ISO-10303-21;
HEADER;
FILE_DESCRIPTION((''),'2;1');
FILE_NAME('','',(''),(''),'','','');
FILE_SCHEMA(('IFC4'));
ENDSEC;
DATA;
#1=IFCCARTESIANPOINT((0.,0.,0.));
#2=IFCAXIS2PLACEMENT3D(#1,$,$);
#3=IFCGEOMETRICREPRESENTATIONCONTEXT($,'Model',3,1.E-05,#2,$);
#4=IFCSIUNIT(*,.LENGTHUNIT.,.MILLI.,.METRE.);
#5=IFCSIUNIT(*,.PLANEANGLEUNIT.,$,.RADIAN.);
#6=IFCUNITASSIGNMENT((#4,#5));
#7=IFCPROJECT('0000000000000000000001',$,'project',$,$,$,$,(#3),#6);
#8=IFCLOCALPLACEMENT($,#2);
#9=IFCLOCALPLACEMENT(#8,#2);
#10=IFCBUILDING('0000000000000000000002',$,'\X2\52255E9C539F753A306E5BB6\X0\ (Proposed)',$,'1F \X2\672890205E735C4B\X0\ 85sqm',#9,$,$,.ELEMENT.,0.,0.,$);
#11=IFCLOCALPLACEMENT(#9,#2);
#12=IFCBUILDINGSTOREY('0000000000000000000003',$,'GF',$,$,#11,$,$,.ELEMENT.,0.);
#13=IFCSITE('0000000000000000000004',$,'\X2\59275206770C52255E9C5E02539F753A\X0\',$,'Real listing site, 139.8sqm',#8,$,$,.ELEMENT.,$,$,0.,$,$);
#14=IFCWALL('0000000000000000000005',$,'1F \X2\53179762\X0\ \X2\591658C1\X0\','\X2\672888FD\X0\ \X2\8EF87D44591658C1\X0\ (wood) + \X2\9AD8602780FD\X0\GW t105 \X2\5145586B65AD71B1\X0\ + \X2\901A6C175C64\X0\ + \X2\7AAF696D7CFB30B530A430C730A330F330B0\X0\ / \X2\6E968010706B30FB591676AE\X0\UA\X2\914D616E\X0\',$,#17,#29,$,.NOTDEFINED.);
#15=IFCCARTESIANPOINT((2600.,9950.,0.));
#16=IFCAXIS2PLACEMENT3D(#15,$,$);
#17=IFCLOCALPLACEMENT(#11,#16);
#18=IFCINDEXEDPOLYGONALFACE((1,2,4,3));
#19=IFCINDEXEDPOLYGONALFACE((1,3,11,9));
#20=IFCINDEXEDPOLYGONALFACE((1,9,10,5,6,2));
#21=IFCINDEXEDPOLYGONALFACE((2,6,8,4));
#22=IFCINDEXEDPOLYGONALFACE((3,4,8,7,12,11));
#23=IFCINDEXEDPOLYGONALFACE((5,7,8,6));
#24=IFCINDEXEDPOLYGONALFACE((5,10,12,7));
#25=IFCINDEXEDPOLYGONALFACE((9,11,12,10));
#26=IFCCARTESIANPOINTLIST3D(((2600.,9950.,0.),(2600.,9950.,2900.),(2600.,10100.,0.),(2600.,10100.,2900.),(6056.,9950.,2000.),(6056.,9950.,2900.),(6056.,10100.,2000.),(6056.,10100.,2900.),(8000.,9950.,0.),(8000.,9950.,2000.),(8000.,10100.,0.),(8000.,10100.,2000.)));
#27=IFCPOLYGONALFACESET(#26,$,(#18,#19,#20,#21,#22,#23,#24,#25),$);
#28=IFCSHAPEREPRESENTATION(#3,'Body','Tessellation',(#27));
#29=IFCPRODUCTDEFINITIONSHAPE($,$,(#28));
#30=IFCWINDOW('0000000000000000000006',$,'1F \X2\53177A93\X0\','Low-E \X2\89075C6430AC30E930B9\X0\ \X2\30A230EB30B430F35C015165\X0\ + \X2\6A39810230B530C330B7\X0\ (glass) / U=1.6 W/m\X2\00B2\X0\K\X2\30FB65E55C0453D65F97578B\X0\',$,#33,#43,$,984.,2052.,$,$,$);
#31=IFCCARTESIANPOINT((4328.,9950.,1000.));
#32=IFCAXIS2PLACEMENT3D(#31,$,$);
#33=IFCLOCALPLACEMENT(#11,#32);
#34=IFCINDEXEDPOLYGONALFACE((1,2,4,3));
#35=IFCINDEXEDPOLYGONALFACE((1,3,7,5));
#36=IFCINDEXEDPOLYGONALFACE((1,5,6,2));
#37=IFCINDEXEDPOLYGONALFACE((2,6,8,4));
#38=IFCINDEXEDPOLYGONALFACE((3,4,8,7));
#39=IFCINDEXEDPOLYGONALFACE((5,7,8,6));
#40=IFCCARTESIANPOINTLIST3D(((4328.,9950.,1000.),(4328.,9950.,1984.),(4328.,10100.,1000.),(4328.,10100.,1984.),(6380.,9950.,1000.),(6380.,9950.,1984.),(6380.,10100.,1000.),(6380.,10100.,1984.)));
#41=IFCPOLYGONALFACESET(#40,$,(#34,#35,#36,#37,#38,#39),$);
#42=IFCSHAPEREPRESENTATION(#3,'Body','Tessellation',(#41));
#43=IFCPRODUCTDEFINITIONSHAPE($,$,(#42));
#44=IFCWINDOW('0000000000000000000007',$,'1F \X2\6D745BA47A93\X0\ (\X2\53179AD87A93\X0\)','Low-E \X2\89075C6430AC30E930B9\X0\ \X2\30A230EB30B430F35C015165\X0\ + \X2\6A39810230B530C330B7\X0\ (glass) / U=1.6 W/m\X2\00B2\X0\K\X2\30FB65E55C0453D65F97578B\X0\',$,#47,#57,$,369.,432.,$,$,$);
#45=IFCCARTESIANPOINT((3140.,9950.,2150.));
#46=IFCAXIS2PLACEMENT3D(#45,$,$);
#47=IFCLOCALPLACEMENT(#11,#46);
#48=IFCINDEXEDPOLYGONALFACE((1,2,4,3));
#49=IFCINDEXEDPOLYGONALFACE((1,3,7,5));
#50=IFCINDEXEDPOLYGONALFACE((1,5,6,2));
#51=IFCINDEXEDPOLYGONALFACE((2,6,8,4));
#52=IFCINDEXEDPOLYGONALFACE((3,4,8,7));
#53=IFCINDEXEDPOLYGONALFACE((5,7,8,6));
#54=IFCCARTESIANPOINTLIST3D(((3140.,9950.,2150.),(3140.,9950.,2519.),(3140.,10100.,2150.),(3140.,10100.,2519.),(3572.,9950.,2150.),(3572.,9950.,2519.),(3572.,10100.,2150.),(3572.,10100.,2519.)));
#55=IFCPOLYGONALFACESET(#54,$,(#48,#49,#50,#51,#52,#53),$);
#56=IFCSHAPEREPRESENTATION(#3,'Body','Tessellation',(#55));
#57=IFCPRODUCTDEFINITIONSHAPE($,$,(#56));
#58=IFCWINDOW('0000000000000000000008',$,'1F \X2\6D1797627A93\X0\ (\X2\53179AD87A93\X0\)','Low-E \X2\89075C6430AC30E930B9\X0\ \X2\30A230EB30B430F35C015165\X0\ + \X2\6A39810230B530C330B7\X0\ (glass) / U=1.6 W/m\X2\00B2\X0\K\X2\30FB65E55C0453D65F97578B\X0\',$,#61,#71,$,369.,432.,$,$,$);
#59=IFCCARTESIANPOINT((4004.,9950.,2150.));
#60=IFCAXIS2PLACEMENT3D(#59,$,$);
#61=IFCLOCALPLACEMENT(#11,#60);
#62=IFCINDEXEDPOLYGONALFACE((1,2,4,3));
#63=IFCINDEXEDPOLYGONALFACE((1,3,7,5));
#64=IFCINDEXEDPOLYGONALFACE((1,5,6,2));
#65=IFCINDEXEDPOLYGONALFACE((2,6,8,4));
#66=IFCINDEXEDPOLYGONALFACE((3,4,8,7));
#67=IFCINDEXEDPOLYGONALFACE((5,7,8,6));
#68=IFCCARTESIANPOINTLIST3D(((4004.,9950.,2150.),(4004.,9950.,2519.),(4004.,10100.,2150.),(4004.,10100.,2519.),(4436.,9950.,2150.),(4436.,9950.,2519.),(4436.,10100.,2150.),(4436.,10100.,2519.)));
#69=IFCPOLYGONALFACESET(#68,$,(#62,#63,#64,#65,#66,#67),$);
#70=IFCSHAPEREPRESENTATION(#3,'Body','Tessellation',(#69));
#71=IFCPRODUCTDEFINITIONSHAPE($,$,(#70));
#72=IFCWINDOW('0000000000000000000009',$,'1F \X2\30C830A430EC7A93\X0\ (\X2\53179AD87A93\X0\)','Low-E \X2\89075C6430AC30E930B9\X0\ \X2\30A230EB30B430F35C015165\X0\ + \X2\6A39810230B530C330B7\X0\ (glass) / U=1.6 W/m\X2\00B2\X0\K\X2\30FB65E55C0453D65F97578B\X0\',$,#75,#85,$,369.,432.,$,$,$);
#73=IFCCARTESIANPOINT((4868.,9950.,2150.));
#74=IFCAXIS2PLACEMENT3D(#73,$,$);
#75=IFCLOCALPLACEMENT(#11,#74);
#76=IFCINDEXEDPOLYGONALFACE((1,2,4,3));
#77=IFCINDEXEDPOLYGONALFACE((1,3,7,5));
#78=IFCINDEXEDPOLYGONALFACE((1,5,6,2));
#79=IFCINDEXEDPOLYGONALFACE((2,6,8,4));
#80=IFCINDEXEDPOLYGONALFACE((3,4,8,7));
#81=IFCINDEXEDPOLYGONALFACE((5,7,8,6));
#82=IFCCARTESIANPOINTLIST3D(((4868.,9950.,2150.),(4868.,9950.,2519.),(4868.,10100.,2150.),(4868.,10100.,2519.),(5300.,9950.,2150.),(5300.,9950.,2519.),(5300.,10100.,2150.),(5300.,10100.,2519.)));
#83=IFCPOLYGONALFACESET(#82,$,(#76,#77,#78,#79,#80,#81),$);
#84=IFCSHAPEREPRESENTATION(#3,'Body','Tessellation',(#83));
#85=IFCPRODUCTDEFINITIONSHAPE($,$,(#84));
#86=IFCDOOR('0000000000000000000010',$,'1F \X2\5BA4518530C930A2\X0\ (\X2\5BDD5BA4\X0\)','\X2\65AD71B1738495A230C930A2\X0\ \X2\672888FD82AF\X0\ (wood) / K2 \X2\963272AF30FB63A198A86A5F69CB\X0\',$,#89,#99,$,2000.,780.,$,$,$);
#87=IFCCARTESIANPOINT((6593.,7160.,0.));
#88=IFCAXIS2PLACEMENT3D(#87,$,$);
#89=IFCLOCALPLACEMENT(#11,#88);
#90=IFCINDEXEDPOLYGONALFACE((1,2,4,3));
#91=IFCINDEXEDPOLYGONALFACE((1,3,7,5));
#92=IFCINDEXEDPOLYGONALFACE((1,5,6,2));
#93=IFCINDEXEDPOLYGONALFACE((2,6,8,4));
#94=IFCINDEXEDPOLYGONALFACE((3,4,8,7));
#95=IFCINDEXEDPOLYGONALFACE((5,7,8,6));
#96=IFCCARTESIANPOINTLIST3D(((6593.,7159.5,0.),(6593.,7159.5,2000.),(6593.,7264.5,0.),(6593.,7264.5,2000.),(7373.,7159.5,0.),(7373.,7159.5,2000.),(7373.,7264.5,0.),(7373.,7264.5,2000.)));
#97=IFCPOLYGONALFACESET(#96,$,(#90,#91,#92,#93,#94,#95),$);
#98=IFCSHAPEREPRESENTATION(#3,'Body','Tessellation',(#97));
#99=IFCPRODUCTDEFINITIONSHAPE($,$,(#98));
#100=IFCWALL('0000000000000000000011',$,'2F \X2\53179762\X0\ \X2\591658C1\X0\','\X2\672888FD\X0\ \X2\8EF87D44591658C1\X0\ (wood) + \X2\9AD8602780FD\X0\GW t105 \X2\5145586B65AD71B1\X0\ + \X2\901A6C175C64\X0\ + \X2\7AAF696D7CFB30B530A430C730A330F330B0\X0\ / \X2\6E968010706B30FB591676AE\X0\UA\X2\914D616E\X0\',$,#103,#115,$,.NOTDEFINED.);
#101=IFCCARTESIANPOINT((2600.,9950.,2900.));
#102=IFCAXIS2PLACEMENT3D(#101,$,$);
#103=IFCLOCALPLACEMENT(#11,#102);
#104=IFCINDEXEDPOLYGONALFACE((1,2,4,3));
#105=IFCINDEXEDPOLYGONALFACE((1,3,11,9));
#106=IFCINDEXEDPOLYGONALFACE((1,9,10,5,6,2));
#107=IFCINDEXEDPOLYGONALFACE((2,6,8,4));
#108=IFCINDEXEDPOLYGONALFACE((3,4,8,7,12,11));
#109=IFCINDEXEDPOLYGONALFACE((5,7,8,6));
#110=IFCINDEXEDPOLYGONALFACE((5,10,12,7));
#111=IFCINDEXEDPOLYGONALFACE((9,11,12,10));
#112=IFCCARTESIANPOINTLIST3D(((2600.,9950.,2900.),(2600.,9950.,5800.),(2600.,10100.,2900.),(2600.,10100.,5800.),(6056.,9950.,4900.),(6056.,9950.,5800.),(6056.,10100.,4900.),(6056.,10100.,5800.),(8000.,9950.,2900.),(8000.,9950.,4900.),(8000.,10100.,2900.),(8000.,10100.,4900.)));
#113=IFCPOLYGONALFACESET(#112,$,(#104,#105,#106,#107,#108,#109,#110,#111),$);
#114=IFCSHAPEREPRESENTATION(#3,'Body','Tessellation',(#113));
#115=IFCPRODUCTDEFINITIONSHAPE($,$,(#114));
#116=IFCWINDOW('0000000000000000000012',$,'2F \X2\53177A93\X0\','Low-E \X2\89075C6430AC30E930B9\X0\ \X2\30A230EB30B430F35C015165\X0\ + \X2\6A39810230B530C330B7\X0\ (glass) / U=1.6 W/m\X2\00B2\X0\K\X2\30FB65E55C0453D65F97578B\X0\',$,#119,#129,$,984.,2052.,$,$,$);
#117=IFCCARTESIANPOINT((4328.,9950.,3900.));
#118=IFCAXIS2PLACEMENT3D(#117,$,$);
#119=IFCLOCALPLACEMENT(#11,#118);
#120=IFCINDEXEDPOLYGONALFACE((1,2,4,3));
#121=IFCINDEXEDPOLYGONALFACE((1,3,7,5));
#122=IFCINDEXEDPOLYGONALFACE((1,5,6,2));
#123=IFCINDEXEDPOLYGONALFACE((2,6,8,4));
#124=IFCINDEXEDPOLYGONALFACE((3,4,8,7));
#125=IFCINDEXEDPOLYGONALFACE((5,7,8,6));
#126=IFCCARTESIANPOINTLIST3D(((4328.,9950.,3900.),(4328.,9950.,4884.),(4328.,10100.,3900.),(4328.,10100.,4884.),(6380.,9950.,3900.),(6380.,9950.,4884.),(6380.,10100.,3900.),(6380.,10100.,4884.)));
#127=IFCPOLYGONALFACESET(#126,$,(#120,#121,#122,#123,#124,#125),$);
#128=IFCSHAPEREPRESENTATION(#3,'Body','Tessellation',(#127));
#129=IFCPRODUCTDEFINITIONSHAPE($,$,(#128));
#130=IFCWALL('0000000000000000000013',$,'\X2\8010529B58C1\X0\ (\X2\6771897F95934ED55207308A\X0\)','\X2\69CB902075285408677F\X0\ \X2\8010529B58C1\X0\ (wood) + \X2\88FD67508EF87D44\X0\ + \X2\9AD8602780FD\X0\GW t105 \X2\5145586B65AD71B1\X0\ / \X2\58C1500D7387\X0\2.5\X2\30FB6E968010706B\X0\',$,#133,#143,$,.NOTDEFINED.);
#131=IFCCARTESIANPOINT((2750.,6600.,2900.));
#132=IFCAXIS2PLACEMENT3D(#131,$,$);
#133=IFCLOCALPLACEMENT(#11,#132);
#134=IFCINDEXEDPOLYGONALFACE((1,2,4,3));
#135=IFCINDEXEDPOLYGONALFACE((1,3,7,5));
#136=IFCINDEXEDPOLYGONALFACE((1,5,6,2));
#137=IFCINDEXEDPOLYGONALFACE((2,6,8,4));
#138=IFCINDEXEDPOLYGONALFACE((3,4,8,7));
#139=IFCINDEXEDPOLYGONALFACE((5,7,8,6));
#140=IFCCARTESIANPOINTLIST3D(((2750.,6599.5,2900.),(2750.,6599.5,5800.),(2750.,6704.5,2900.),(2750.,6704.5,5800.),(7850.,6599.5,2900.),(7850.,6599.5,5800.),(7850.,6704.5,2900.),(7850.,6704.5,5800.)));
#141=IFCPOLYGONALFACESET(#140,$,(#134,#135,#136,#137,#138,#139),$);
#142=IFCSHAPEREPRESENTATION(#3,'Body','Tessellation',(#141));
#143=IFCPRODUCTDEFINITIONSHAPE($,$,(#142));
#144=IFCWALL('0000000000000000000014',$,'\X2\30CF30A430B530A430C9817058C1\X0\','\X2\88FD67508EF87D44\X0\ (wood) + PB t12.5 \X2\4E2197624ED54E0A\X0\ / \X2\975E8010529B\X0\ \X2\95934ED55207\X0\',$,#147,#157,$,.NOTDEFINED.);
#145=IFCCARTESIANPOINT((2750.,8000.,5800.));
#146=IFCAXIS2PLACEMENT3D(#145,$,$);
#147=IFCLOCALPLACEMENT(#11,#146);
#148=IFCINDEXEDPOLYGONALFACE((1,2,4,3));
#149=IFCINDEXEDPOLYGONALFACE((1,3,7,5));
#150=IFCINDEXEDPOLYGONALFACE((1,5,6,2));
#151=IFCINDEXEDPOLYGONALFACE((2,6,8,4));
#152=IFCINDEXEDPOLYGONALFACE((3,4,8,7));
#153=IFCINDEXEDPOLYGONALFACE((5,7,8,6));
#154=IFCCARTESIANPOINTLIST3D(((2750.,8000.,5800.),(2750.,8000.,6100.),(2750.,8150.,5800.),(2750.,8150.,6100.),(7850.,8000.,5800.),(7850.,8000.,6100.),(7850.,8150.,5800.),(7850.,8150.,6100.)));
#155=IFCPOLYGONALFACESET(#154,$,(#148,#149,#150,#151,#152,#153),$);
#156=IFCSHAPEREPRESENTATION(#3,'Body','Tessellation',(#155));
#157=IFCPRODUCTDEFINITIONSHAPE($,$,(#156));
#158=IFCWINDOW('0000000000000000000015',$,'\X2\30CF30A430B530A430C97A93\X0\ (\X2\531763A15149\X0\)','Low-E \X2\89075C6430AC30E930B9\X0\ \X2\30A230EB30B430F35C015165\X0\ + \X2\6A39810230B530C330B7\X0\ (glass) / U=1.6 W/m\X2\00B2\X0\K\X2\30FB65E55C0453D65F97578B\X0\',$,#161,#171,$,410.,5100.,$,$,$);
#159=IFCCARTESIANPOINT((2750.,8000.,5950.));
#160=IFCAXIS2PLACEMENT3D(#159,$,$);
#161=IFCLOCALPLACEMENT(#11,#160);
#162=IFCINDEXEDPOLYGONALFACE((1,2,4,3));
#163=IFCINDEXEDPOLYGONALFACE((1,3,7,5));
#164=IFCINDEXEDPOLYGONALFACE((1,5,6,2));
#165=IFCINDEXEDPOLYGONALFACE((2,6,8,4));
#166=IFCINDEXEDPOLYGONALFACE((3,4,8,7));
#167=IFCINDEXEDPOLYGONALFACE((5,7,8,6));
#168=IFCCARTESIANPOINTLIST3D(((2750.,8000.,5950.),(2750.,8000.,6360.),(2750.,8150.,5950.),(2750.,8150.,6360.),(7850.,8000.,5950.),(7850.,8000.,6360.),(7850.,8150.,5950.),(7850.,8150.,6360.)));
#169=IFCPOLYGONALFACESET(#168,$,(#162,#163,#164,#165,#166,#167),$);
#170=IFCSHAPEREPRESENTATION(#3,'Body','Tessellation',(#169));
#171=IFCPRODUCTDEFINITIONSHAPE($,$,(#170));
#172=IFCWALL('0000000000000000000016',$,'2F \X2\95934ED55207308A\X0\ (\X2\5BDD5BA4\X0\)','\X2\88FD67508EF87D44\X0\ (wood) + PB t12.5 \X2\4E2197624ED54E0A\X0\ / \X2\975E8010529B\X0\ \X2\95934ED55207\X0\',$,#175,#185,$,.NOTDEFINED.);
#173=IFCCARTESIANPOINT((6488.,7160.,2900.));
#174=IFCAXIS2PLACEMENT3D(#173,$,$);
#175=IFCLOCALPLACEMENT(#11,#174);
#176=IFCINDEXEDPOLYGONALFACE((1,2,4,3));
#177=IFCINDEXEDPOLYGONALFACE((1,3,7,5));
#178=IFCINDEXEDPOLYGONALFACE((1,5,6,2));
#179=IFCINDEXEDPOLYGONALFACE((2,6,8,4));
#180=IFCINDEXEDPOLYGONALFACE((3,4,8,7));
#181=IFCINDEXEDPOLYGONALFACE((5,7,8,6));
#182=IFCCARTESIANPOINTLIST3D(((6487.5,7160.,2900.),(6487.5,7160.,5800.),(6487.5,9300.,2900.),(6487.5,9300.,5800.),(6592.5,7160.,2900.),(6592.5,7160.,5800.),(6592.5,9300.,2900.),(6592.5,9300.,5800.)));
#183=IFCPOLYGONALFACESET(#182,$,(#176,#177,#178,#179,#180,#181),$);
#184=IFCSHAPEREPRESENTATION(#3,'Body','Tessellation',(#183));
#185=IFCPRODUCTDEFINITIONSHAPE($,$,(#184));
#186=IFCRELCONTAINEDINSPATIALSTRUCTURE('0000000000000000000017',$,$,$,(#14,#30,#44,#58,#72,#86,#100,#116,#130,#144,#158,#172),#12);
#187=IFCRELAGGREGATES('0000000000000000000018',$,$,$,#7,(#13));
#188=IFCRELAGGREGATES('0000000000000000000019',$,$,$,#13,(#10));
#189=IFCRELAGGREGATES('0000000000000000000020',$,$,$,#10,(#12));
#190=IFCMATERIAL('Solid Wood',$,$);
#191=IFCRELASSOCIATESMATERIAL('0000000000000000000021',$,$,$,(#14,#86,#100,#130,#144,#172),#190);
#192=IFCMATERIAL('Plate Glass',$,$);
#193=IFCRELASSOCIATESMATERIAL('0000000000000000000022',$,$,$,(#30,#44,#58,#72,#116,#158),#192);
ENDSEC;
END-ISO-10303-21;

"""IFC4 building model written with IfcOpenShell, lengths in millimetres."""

from ifc_helpers import new_model, si_unit, frame, frame_2d, origin, place, context, project, spatial, rectangle, extrude, material, element, fill, save


model = new_model("IFC4")

# Units and contexts
model_context = context("Model", 3, precision=1e-05, world=origin())
ifc_project = project(units=[si_unit("LENGTHUNIT", "METRE", prefix="MILLI"), si_unit("PLANEANGLEUNIT", "RADIAN")], contexts=[model_context])

# Site, building, storey
site_placement = place(None, origin())
site = spatial("IfcSite", under=ifc_project, at=site_placement, Name="大分県別府市原町", ObjectType="Real listing site, 139.8sqm", CompositionType="ELEMENT", RefElevation=0.0)
building_placement = place(site_placement, origin())
building = spatial("IfcBuilding", under=site, at=building_placement, Name="別府原町の家 (Proposed)", ObjectType="1F 木造平屋 85sqm", CompositionType="ELEMENT", ElevationOfRefHeight=0.0, ElevationOfTerrain=0.0)
storey_placement = place(building_placement, origin())
storey = spatial("IfcBuildingStorey", under=building, at=storey_placement, Name="GF", CompositionType="ELEMENT", Elevation=0.0)

# Wall, openings, windows
ifc_material_1 = material(Name="Solid Wood")
wall_1_placement = place(storey_placement, frame((2600.0, 9950.0, 0.0)))
wall_1 = element("IfcWall", 1, at=wall_1_placement, inside=storey, material=ifc_material_1, Name="1F 北面 外壁", Description="木製 軸組外壁 (wood) + 高性能GW t105 充填断熱 + 通気層 + 窯業系サイディング / 準耐火・外皮UA配慮", PredefinedType="NOTDEFINED", context=model_context, shape_type="SweptSolid", body=[
    extrude(rectangle(XDim=5400.0, YDim=150.0, at=frame_2d((2700.0, 75.0))), frame((2600.0, 9950.0, 0.0)), (0.0, 0.0, 1.0), 2900.0),
])
opening_1_placement = place(storey_placement, frame((4328.0, 9950.0, 1000.0)))
opening_1 = element("IfcOpeningElement", 2, at=opening_1_placement, cuts=wall_1, PredefinedType="NOTDEFINED", context=model_context, shape_type="SweptSolid", body=[
    extrude(rectangle(XDim=2052.0, YDim=150.0, at=frame_2d((1026.0, 75.0))), frame((4328.0, 9950.0, 1000.0)), (0.0, 0.0, 1.0), 984.0),
])
opening_2_placement = place(storey_placement, frame((3140.0, 9950.0, 2150.0)))
opening_2 = element("IfcOpeningElement", 3, at=opening_2_placement, cuts=wall_1, PredefinedType="NOTDEFINED", context=model_context, shape_type="SweptSolid", body=[
    extrude(rectangle(XDim=432.0, YDim=150.0, at=frame_2d((216.0, 75.0))), frame((3140.0, 9950.0, 2150.0)), (0.0, 0.0, 1.0), 369.0),
])
opening_3_placement = place(storey_placement, frame((4004.0, 9950.0, 2150.0)))
opening_3 = element("IfcOpeningElement", 4, at=opening_3_placement, cuts=wall_1, PredefinedType="NOTDEFINED", context=model_context, shape_type="SweptSolid", body=[
    extrude(rectangle(XDim=432.0, YDim=150.0, at=frame_2d((216.0, 75.0))), frame((4004.0, 9950.0, 2150.0)), (0.0, 0.0, 1.0), 369.0),
])
opening_4_placement = place(storey_placement, frame((4868.0, 9950.0, 2150.0)))
opening_4 = element("IfcOpeningElement", 5, at=opening_4_placement, cuts=wall_1, PredefinedType="NOTDEFINED", context=model_context, shape_type="SweptSolid", body=[
    extrude(rectangle(XDim=432.0, YDim=150.0, at=frame_2d((216.0, 75.0))), frame((4868.0, 9950.0, 2150.0)), (0.0, 0.0, 1.0), 369.0),
])
ifc_material_2 = material(Name="Plate Glass")
window_1_placement = place(storey_placement, frame((4328.0, 9950.0, 1000.0)))
window_1 = element("IfcWindow", 6, at=window_1_placement, inside=storey, material=ifc_material_2, Name="1F 北窓", Description="Low-E 複層ガラス アルゴン封入 + 樹脂サッシ (glass) / U=1.6 W/m²K・日射取得型", OverallHeight=984.0, OverallWidth=2052.0, context=model_context, shape_type="SweptSolid", body=[
    extrude(rectangle(XDim=2052.0, YDim=150.0, at=frame_2d((1026.0, 75.0))), frame((4328.0, 9950.0, 1000.0)), (0.0, 0.0, 1.0), 984.0),
])
fill(opening_1, window_1)
window_2_placement = place(storey_placement, frame((3140.0, 9950.0, 2150.0)))
window_2 = element("IfcWindow", 7, at=window_2_placement, inside=storey, material=ifc_material_2, Name="1F 浴室窓 (北高窓)", Description="Low-E 複層ガラス アルゴン封入 + 樹脂サッシ (glass) / U=1.6 W/m²K・日射取得型", OverallHeight=369.0, OverallWidth=432.0, context=model_context, shape_type="SweptSolid", body=[
    extrude(rectangle(XDim=432.0, YDim=150.0, at=frame_2d((216.0, 75.0))), frame((3140.0, 9950.0, 2150.0)), (0.0, 0.0, 1.0), 369.0),
])
fill(opening_2, window_2)
window_3_placement = place(storey_placement, frame((4004.0, 9950.0, 2150.0)))
window_3 = element("IfcWindow", 8, at=window_3_placement, inside=storey, material=ifc_material_2, Name="1F 洗面窓 (北高窓)", Description="Low-E 複層ガラス アルゴン封入 + 樹脂サッシ (glass) / U=1.6 W/m²K・日射取得型", OverallHeight=369.0, OverallWidth=432.0, context=model_context, shape_type="SweptSolid", body=[
    extrude(rectangle(XDim=432.0, YDim=150.0, at=frame_2d((216.0, 75.0))), frame((4004.0, 9950.0, 2150.0)), (0.0, 0.0, 1.0), 369.0),
])
fill(opening_3, window_3)
window_4_placement = place(storey_placement, frame((4868.0, 9950.0, 2150.0)))
window_4 = element("IfcWindow", 9, at=window_4_placement, inside=storey, material=ifc_material_2, Name="1F トイレ窓 (北高窓)", Description="Low-E 複層ガラス アルゴン封入 + 樹脂サッシ (glass) / U=1.6 W/m²K・日射取得型", OverallHeight=369.0, OverallWidth=432.0, context=model_context, shape_type="SweptSolid", body=[
    extrude(rectangle(XDim=432.0, YDim=150.0, at=frame_2d((216.0, 75.0))), frame((4868.0, 9950.0, 2150.0)), (0.0, 0.0, 1.0), 369.0),
])
fill(opening_4, window_4)

# Door
door_1_placement = place(storey_placement, frame((6593.0, 7160.0, 0.0)))
element("IfcDoor", 10, at=door_1_placement, inside=storey, material=ifc_material_1, Name="1F 室内ドア (寝室)", Description="断熱玄関ドア 木製芯 (wood) / K2 防犯・採風機構", OverallHeight=2000.0, OverallWidth=780.0, context=model_context, shape_type="SweptSolid", body=[
    extrude(rectangle(XDim=780.0, YDim=105.0, at=frame_2d((390.0, 52.0))), frame((6593.0, 7160.0, 0.0)), (0.0, 0.0, 1.0), 2000.0),
])

# Wall, opening, window
wall_2_placement = place(storey_placement, frame((2600.0, 9950.0, 2900.0)))
wall_2 = element("IfcWall", 11, at=wall_2_placement, inside=storey, material=ifc_material_1, Name="2F 北面 外壁", Description="木製 軸組外壁 (wood) + 高性能GW t105 充填断熱 + 通気層 + 窯業系サイディング / 準耐火・外皮UA配慮", PredefinedType="NOTDEFINED", context=model_context, shape_type="SweptSolid", body=[
    extrude(rectangle(XDim=5400.0, YDim=150.0, at=frame_2d((2700.0, 75.0))), frame((2600.0, 9950.0, 2900.0)), (0.0, 0.0, 1.0), 2900.0),
])
opening_5_placement = place(storey_placement, frame((4328.0, 9950.0, 3900.0)))
opening_5 = element("IfcOpeningElement", 12, at=opening_5_placement, cuts=wall_2, PredefinedType="NOTDEFINED", context=model_context, shape_type="SweptSolid", body=[
    extrude(rectangle(XDim=2052.0, YDim=150.0, at=frame_2d((1026.0, 75.0))), frame((4328.0, 9950.0, 3900.0)), (0.0, 0.0, 1.0), 984.0),
])
window_5_placement = place(storey_placement, frame((4328.0, 9950.0, 3900.0)))
window_5 = element("IfcWindow", 13, at=window_5_placement, inside=storey, material=ifc_material_2, Name="2F 北窓", Description="Low-E 複層ガラス アルゴン封入 + 樹脂サッシ (glass) / U=1.6 W/m²K・日射取得型", OverallHeight=984.0, OverallWidth=2052.0, context=model_context, shape_type="SweptSolid", body=[
    extrude(rectangle(XDim=2052.0, YDim=150.0, at=frame_2d((1026.0, 75.0))), frame((4328.0, 9950.0, 3900.0)), (0.0, 0.0, 1.0), 984.0),
])
fill(opening_5, window_5)

# Wall
wall_3_placement = place(storey_placement, frame((2750.0, 6600.0, 2900.0)))
element("IfcWall", 14, at=wall_3_placement, inside=storey, material=ifc_material_1, Name="耐力壁 (東西間仕切り)", Description="構造用合板 耐力壁 (wood) + 製材軸組 + 高性能GW t105 充填断熱 / 壁倍率2.5・準耐火", PredefinedType="NOTDEFINED", context=model_context, shape_type="SweptSolid", body=[
    extrude(rectangle(XDim=5100.0, YDim=105.0, at=frame_2d((2550.0, 52.0))), frame((2750.0, 6600.0, 2900.0)), (0.0, 0.0, 1.0), 2900.0),
])

# Wall, opening, window
wall_4_placement = place(storey_placement, frame((2750.0, 8000.0, 5800.0)))
wall_4 = element("IfcWall", 15, at=wall_4_placement, inside=storey, material=ifc_material_1, Name="ハイサイド腰壁", Description="製材軸組 (wood) + PB t12.5 両面仕上 / 非耐力 間仕切", PredefinedType="NOTDEFINED", context=model_context, shape_type="SweptSolid", body=[
    extrude(rectangle(XDim=5100.0, YDim=150.0, at=frame_2d((2550.0, 75.0))), frame((2750.0, 8000.0, 5800.0)), (0.0, 0.0, 1.0), 700.0),
])
opening_6_placement = place(storey_placement, frame((2750.0, 8000.0, 5950.0)))
opening_6 = element("IfcOpeningElement", 16, at=opening_6_placement, cuts=wall_4, PredefinedType="NOTDEFINED", context=model_context, shape_type="SweptSolid", body=[
    extrude(rectangle(XDim=5100.0, YDim=150.0, at=frame_2d((2550.0, 75.0))), frame((2750.0, 8000.0, 5950.0)), (0.0, 0.0, 1.0), 410.0),
])
window_6_placement = place(storey_placement, frame((2750.0, 8000.0, 5950.0)))
window_6 = element("IfcWindow", 17, at=window_6_placement, inside=storey, material=ifc_material_2, Name="ハイサイド窓 (北採光)", Description="Low-E 複層ガラス アルゴン封入 + 樹脂サッシ (glass) / U=1.6 W/m²K・日射取得型", OverallHeight=410.0, OverallWidth=5100.0, context=model_context, shape_type="SweptSolid", body=[
    extrude(rectangle(XDim=5100.0, YDim=150.0, at=frame_2d((2550.0, 75.0))), frame((2750.0, 8000.0, 5950.0)), (0.0, 0.0, 1.0), 410.0),
])
fill(opening_6, window_6)

# Wall
wall_5_placement = place(storey_placement, frame((6488.0, 7160.0, 2900.0)))
element("IfcWall", 18, at=wall_5_placement, inside=storey, material=ifc_material_1, Name="2F 間仕切り (寝室)", Description="製材軸組 (wood) + PB t12.5 両面仕上 / 非耐力 間仕切", PredefinedType="NOTDEFINED", context=model_context, shape_type="SweptSolid", body=[
    extrude(rectangle(XDim=105.0, YDim=2140.0, at=frame_2d((52.0, 1070.0))), frame((6488.0, 7160.0, 2900.0)), (0.0, 0.0, 1.0), 2900.0),
])

save(model, "model.ifc")
